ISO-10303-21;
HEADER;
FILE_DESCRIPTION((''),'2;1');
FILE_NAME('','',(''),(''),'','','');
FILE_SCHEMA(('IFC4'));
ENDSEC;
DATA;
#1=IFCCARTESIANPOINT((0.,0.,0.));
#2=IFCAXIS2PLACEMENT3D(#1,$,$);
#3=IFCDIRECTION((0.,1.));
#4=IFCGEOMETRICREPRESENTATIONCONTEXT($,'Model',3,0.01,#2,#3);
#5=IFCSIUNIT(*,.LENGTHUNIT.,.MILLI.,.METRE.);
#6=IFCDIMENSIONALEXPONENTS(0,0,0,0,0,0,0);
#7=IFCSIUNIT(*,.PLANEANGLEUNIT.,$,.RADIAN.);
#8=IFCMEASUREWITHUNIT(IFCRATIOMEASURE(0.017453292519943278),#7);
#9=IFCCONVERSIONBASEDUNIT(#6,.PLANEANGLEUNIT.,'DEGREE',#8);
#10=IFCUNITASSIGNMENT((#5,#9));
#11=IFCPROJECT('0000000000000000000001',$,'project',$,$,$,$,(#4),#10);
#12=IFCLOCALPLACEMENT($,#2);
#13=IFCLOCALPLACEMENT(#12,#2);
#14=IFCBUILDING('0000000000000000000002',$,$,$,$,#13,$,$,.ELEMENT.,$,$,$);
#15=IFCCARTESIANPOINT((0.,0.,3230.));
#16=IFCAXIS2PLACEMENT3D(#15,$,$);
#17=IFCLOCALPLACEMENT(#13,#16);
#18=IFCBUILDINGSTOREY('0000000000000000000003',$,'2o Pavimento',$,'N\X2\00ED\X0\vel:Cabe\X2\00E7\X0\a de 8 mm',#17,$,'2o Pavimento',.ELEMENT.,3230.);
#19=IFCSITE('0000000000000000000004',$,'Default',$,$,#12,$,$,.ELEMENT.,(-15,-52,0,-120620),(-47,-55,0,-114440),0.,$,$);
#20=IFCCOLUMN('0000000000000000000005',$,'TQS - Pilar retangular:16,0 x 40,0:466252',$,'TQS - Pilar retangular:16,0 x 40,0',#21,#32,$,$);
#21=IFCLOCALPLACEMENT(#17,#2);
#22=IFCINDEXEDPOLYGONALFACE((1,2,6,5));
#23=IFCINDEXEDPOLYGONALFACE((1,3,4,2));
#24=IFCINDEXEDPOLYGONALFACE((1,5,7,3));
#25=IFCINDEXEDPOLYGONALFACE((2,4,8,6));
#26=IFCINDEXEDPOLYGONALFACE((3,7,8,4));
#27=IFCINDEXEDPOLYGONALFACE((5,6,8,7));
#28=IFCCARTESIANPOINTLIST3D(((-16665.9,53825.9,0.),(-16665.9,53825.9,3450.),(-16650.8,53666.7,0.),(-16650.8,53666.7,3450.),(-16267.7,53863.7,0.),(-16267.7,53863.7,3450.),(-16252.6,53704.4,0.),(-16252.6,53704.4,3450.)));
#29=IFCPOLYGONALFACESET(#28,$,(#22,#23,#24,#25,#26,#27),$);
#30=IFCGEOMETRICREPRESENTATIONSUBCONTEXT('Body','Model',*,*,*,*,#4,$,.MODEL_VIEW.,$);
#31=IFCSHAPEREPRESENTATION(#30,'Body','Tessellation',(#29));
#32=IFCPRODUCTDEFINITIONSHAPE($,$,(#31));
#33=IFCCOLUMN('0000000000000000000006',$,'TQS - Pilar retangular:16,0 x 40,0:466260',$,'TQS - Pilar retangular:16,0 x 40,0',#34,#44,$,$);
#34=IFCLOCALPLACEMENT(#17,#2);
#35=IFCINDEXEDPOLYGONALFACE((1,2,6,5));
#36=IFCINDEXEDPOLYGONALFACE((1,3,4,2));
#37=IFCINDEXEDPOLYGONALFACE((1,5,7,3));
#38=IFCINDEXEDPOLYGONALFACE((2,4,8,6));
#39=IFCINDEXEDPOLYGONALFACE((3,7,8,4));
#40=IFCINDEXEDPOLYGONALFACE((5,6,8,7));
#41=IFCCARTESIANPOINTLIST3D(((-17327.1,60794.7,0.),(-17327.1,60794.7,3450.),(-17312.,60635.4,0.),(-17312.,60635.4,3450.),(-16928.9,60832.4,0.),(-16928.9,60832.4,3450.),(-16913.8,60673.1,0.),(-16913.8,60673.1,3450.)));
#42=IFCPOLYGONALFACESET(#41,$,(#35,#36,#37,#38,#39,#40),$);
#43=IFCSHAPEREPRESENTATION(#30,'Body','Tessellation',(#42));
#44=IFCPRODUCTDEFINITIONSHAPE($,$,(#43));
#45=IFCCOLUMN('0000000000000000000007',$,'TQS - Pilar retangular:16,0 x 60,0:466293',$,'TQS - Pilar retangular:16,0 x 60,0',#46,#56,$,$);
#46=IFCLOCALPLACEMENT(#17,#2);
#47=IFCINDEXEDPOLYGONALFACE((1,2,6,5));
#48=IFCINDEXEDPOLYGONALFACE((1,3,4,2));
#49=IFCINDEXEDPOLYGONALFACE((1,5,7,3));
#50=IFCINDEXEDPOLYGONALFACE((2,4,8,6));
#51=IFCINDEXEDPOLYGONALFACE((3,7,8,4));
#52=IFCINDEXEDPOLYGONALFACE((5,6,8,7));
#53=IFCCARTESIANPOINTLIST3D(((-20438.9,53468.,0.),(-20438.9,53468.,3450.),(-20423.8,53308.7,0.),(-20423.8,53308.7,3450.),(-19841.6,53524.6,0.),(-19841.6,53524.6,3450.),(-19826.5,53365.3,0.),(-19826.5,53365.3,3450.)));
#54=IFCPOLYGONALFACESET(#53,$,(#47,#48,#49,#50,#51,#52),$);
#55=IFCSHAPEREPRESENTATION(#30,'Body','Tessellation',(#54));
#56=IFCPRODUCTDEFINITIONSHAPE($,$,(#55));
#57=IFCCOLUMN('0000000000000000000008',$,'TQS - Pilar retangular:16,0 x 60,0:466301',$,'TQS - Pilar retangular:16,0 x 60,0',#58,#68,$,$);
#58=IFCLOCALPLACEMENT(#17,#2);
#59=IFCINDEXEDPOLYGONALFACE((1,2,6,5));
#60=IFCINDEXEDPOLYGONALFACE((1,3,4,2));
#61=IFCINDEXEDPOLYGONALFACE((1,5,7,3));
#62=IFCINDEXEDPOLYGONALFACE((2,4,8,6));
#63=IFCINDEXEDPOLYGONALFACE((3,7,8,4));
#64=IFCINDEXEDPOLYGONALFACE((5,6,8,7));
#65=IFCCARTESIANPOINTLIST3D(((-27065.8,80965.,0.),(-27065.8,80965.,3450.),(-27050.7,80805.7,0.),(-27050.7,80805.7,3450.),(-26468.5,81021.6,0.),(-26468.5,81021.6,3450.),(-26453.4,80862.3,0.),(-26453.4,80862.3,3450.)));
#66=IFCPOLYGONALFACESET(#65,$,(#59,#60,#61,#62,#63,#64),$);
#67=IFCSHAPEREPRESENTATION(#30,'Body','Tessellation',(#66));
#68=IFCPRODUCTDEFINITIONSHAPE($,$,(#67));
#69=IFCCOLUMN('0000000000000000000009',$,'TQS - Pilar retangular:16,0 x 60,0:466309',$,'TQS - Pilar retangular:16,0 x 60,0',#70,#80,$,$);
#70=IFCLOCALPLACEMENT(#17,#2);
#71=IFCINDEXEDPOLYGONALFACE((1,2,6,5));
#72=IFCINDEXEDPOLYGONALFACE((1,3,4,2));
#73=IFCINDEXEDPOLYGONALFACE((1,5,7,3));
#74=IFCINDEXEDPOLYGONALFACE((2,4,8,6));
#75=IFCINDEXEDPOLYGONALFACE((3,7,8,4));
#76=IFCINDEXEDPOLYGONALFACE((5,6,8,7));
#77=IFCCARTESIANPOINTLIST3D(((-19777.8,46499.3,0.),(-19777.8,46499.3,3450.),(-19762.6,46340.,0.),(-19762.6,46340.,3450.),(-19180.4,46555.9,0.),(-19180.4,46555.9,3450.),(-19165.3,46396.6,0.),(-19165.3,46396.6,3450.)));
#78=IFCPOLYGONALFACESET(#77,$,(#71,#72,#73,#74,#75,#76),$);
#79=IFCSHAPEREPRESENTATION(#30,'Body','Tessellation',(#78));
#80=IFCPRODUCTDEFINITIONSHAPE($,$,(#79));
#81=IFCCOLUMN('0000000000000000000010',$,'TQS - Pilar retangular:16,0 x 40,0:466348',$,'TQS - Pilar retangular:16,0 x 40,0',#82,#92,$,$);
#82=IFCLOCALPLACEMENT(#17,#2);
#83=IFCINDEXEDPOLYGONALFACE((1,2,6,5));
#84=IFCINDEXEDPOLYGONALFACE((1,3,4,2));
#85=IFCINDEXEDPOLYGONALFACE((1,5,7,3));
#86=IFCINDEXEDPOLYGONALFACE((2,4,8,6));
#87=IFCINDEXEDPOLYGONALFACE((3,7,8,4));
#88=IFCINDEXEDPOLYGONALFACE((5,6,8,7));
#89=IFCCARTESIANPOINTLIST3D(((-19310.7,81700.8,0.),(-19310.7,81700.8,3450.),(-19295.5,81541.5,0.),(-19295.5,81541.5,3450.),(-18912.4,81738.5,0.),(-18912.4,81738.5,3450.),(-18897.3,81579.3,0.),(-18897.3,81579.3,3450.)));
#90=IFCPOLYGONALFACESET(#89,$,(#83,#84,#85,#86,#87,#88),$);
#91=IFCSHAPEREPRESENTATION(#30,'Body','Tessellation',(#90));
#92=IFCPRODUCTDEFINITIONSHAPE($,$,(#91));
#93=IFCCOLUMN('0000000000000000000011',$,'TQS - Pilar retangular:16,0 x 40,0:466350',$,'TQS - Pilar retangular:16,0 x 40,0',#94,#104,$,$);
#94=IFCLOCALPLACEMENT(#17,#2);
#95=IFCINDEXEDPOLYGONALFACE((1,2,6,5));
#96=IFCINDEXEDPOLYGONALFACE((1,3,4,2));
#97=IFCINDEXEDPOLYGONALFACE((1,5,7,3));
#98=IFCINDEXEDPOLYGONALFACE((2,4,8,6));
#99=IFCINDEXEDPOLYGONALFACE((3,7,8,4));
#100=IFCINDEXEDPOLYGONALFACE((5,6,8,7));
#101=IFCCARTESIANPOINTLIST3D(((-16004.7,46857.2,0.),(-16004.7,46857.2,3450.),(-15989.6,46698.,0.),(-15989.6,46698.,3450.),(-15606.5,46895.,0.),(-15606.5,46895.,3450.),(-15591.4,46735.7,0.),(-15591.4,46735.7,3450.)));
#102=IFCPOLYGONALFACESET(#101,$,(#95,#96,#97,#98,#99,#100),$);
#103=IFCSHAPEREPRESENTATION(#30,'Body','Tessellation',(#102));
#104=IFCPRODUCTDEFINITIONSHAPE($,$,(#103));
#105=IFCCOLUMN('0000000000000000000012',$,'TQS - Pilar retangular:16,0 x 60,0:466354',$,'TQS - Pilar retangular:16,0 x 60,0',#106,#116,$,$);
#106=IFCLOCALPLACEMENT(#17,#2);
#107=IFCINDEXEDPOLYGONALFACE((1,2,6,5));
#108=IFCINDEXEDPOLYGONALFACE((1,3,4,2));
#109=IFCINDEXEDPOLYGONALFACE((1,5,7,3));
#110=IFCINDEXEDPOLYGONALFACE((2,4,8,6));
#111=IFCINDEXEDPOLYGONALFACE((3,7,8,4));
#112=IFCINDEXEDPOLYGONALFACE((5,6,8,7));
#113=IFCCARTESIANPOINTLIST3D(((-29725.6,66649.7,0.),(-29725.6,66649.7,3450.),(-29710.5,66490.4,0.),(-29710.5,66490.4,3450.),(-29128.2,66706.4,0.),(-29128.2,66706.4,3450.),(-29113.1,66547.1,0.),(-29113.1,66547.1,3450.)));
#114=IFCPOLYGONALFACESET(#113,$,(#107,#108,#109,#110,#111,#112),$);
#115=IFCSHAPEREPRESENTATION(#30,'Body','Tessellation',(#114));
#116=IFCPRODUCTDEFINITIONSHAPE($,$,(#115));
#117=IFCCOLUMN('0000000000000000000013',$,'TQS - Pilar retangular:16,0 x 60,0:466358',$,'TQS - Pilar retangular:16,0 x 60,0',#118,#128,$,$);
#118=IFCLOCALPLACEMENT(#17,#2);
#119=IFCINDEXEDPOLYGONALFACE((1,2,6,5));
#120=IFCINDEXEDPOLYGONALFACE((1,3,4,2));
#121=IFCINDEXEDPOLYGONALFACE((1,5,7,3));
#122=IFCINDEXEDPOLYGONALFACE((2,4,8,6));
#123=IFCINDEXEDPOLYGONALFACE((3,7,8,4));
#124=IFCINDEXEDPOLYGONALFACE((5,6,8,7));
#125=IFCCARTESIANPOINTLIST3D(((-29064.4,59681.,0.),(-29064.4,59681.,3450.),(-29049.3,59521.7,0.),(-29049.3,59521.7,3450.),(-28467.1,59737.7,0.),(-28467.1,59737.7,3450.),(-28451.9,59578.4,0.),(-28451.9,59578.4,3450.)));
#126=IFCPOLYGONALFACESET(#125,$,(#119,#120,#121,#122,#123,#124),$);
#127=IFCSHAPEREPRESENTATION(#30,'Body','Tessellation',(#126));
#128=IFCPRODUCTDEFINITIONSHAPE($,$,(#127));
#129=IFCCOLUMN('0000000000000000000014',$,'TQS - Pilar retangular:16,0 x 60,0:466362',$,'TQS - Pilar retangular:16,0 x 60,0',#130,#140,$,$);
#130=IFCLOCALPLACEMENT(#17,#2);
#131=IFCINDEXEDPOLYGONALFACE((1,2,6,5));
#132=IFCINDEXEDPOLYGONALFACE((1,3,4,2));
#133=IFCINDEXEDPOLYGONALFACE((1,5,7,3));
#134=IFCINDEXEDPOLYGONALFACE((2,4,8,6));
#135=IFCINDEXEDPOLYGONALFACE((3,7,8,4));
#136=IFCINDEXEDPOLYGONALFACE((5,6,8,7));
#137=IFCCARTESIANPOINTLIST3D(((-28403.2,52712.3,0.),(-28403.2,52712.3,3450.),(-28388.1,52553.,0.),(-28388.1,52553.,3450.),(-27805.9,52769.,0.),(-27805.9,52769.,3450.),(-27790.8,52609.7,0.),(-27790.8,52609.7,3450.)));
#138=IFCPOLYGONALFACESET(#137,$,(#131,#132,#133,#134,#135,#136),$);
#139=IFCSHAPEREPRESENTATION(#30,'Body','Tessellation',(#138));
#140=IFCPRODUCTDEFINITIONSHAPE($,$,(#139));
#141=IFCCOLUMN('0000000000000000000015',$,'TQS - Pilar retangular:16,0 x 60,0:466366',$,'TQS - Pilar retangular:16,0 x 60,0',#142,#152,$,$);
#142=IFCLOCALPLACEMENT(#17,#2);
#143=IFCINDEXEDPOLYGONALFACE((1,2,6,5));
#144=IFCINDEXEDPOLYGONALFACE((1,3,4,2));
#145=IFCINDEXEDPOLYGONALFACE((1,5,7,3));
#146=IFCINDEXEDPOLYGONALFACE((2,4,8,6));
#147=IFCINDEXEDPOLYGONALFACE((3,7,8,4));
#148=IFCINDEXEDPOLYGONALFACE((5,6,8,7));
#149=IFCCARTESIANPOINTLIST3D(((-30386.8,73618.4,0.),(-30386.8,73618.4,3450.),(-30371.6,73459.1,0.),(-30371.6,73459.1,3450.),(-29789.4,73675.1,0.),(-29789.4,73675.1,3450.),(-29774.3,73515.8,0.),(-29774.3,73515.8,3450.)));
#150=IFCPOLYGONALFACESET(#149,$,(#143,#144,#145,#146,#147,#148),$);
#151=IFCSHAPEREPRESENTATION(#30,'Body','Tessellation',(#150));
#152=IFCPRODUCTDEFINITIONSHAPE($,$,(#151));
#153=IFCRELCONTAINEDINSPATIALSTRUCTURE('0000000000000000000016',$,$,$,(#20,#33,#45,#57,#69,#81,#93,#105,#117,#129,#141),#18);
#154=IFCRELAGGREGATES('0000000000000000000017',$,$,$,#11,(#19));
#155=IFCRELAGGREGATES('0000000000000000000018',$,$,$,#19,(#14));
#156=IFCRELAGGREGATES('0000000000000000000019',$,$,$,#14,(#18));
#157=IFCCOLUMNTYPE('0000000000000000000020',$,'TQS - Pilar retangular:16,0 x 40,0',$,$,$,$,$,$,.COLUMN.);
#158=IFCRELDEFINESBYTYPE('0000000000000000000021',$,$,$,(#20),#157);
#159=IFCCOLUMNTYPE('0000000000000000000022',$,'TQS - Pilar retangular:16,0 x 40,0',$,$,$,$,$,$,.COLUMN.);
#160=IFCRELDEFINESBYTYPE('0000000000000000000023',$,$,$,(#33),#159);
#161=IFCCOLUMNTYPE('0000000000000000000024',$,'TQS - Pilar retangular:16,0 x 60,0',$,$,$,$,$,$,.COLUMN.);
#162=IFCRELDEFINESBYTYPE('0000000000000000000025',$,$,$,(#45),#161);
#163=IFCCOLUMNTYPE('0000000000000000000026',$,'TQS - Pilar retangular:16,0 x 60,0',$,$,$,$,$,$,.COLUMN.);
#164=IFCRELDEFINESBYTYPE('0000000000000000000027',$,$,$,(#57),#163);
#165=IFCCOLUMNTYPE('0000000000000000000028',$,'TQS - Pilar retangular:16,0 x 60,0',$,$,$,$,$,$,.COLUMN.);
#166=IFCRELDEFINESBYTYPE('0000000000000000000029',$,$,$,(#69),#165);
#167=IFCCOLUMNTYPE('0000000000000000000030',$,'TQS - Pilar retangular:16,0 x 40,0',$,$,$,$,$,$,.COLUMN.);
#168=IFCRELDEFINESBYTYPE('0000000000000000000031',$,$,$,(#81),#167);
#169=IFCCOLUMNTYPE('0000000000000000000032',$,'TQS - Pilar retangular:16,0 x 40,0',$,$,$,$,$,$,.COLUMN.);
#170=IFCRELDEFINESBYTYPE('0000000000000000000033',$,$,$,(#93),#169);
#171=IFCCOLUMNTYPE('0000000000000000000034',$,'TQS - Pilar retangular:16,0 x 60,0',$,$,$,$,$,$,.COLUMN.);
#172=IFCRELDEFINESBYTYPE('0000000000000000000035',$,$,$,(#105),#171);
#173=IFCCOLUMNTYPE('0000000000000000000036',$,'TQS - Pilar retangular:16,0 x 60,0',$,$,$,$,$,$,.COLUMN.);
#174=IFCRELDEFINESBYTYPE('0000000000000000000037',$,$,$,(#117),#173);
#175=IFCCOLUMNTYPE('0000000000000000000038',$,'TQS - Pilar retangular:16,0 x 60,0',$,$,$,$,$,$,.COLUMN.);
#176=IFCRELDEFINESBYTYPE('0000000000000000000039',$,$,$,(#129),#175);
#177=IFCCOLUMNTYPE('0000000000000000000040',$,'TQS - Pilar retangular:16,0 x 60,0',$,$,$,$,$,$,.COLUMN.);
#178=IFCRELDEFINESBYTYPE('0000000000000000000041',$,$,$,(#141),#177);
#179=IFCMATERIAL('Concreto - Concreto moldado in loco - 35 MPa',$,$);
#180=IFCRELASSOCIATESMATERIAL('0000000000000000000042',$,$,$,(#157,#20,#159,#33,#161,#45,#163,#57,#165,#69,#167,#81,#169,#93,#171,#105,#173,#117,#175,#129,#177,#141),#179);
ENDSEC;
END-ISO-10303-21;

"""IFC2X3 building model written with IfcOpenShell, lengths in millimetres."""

from ifc_helpers import new_model, entity, si_unit, converted_unit, direction, frame, frame_2d, origin, origin_2d_with_axis, place, context, subcontext, project, spatial, rectangle, extrude, source, transform, mapped, material, type_object, type_shapes, element, save


model = new_model("IFC2X3")

# Units and contexts
model_context = context("Model", 3, precision=0.01, world=origin(), true_north=direction((0.0, 1.0)))
body_context = subcontext(model_context, "Body", "Model", "MODEL_VIEW")
ifc_project = project(units=[si_unit("LENGTHUNIT", "METRE", prefix="MILLI"), converted_unit("PLANEANGLEUNIT", "DEGREE", entity("IfcRatioMeasure", 0.017453292519943278), si_unit("PLANEANGLEUNIT", "RADIAN"), dimensions=[0, 0, 0, 0, 0, 0, 0])], contexts=[model_context])

# Site, building, storey
site_placement = place(None, origin())
site = spatial("IfcSite", under=ifc_project, at=site_placement, Name="Default", CompositionType="ELEMENT", RefLatitude=(-15, -52, 0, -120620), RefLongitude=(-47, -55, 0, -114440), RefElevation=0.0)
building_placement = place(site_placement, origin())
building = spatial("IfcBuilding", under=site, at=building_placement, CompositionType="ELEMENT")
storey_placement = place(building_placement, frame((0.0, 0.0, 3230.0)))
storey = spatial("IfcBuildingStorey", under=building, at=storey_placement, Name="2o Pavimento", ObjectType="Nível:Cabeça de 8 mm", LongName="2o Pavimento", CompositionType="ELEMENT", Elevation=3230.0)

# Columns
ifc_material = material(Name="Concreto - Concreto moldado in loco - 35 MPa")
column_type_1 = type_object("IfcColumnType", Name="TQS - Pilar retangular:16,0 x 40,0", PredefinedType="COLUMN", material=ifc_material)
shared_shape_1 = source(origin(), body_context, "Body", "SweptSolid", [
    extrude(rectangle(XDim=400.0, YDim=160.0, at=origin_2d_with_axis()), frame((-16459.2, 53765.2, 3230.0), z_axis=(0.0, 0.0, 1.0), x_axis=(-0.995529, -0.094456, 0.0)), (0.0, 0.0, 1.0), 3450.0),
])
type_shapes(column_type_1, [shared_shape_1])
column_1_placement = place(storey_placement, frame((0.0, 0.0, -3230.0)))
element("IfcColumn", 1, at=column_1_placement, inside=storey, type_object=column_type_1, material=ifc_material, Name="TQS - Pilar retangular:16,0 x 40,0:466252", ObjectType="TQS - Pilar retangular:16,0 x 40,0", context=body_context, shape_type="MappedRepresentation", body=[
    mapped(shared_shape_1, transform((0.0, 0.0, 0.0), scale=1.0)),
])
column_type_2 = type_object("IfcColumnType", Name="TQS - Pilar retangular:16,0 x 40,0", PredefinedType="COLUMN", material=ifc_material)
shared_shape_2 = source(origin(), body_context, "Body", "SweptSolid", [
    extrude(rectangle(XDim=400.0, YDim=160.0, at=origin_2d_with_axis()), frame((-17120.4, 60733.9, 3230.0), z_axis=(0.0, 0.0, 1.0), x_axis=(-0.995529, -0.094456, 0.0)), (0.0, 0.0, 1.0), 3450.0),
])
type_shapes(column_type_2, [shared_shape_2])
column_2_placement = place(storey_placement, frame((0.0, 0.0, -3230.0)))
element("IfcColumn", 2, at=column_2_placement, inside=storey, type_object=column_type_2, material=ifc_material, Name="TQS - Pilar retangular:16,0 x 40,0:466260", ObjectType="TQS - Pilar retangular:16,0 x 40,0", context=body_context, shape_type="MappedRepresentation", body=[
    mapped(shared_shape_2, transform((0.0, 0.0, 0.0), scale=1.0)),
])
column_type_3 = type_object("IfcColumnType", Name="TQS - Pilar retangular:16,0 x 60,0", PredefinedType="COLUMN", material=ifc_material)
shared_shape_3 = source(origin(), body_context, "Body", "SweptSolid", [
    extrude(rectangle(XDim=600.0, YDim=160.0, at=origin_2d_with_axis()), frame((-20132.7, 53416.7, 3230.0), z_axis=(0.0, 0.0, 1.0), x_axis=(-0.995529, -0.094456, 0.0)), (0.0, 0.0, 1.0), 3450.0),
])
type_shapes(column_type_3, [shared_shape_3])
column_3_placement = place(storey_placement, frame((0.0, 0.0, -3230.0)))
element("IfcColumn", 3, at=column_3_placement, inside=storey, type_object=column_type_3, material=ifc_material, Name="TQS - Pilar retangular:16,0 x 60,0:466293", ObjectType="TQS - Pilar retangular:16,0 x 60,0", context=body_context, shape_type="MappedRepresentation", body=[
    mapped(shared_shape_3, transform((0.0, 0.0, 0.0), scale=1.0)),
])
column_type_4 = type_object("IfcColumnType", Name="TQS - Pilar retangular:16,0 x 60,0", PredefinedType="COLUMN", material=ifc_material)
shared_shape_4 = source(origin(), body_context, "Body", "SweptSolid", [
    extrude(rectangle(XDim=600.0, YDim=160.0, at=origin_2d_with_axis()), frame((-26759.6, 80913.6, 3230.0), z_axis=(0.0, 0.0, 1.0), x_axis=(-0.995529, -0.094456, 0.0)), (0.0, 0.0, 1.0), 3450.0),
])
type_shapes(column_type_4, [shared_shape_4])
column_4_placement = place(storey_placement, frame((0.0, 0.0, -3230.0)))
element("IfcColumn", 4, at=column_4_placement, inside=storey, type_object=column_type_4, material=ifc_material, Name="TQS - Pilar retangular:16,0 x 60,0:466301", ObjectType="TQS - Pilar retangular:16,0 x 60,0", context=body_context, shape_type="MappedRepresentation", body=[
    mapped(shared_shape_4, transform((0.0, 0.0, 0.0), scale=1.0)),
])
column_type_5 = type_object("IfcColumnType", Name="TQS - Pilar retangular:16,0 x 60,0", PredefinedType="COLUMN", material=ifc_material)
shared_shape_5 = source(origin(), body_context, "Body", "SweptSolid", [
    extrude(rectangle(XDim=600.0, YDim=160.0, at=origin_2d_with_axis()), frame((-19471.5, 46448.0, 3230.0), z_axis=(0.0, 0.0, 1.0), x_axis=(-0.995529, -0.094456, 0.0)), (0.0, 0.0, 1.0), 3450.0),
])
type_shapes(column_type_5, [shared_shape_5])
column_5_placement = place(storey_placement, frame((0.0, 0.0, -3230.0)))
element("IfcColumn", 5, at=column_5_placement, inside=storey, type_object=column_type_5, material=ifc_material, Name="TQS - Pilar retangular:16,0 x 60,0:466309", ObjectType="TQS - Pilar retangular:16,0 x 60,0", context=body_context, shape_type="MappedRepresentation", body=[
    mapped(shared_shape_5, transform((0.0, 0.0, 0.0), scale=1.0)),
])
column_type_6 = type_object("IfcColumnType", Name="TQS - Pilar retangular:16,0 x 40,0", PredefinedType="COLUMN", material=ifc_material)
shared_shape_6 = source(origin(), body_context, "Body", "SweptSolid", [
    extrude(rectangle(XDim=400.0, YDim=160.0, at=origin_2d_with_axis()), frame((-19104.0, 81640.0, 3230.0), z_axis=(0.0, 0.0, 1.0), x_axis=(-0.995529, -0.094456, 0.0)), (0.0, 0.0, 1.0), 3450.0),
])
type_shapes(column_type_6, [shared_shape_6])
column_6_placement = place(storey_placement, frame((0.0, 0.0, -3230.0)))
element("IfcColumn", 6, at=column_6_placement, inside=storey, type_object=column_type_6, material=ifc_material, Name="TQS - Pilar retangular:16,0 x 40,0:466348", ObjectType="TQS - Pilar retangular:16,0 x 40,0", context=body_context, shape_type="MappedRepresentation", body=[
    mapped(shared_shape_6, transform((0.0, 0.0, 0.0), scale=1.0)),
])
column_type_7 = type_object("IfcColumnType", Name="TQS - Pilar retangular:16,0 x 40,0", PredefinedType="COLUMN", material=ifc_material)
shared_shape_7 = source(origin(), body_context, "Body", "SweptSolid", [
    extrude(rectangle(XDim=400.0, YDim=160.0, at=frame_2d((0.0, 0.0), x_axis=(1.0, 0.0))), frame((-15798.0, 46796.5, 3230.0), z_axis=(0.0, 0.0, 1.0), x_axis=(-0.995529, -0.094456, 0.0)), (0.0, 0.0, 1.0), 3450.0),
])
type_shapes(column_type_7, [shared_shape_7])
column_7_placement = place(storey_placement, frame((0.0, 0.0, -3230.0)))
element("IfcColumn", 7, at=column_7_placement, inside=storey, type_object=column_type_7, material=ifc_material, Name="TQS - Pilar retangular:16,0 x 40,0:466350", ObjectType="TQS - Pilar retangular:16,0 x 40,0", context=body_context, shape_type="MappedRepresentation", body=[
    mapped(shared_shape_7, transform((0.0, 0.0, 0.0), scale=1.0)),
])
column_type_8 = type_object("IfcColumnType", Name="TQS - Pilar retangular:16,0 x 60,0", PredefinedType="COLUMN", material=ifc_material)
shared_shape_8 = source(origin(), body_context, "Body", "SweptSolid", [
    extrude(rectangle(XDim=600.0, YDim=160.0, at=origin_2d_with_axis()), frame((-29419.3, 66598.4, 3230.0), z_axis=(0.0, 0.0, 1.0), x_axis=(-0.995529, -0.094456, 0.0)), (0.0, 0.0, 1.0), 3450.0),
])
type_shapes(column_type_8, [shared_shape_8])
column_8_placement = place(storey_placement, frame((0.0, 0.0, -3230.0)))
element("IfcColumn", 8, at=column_8_placement, inside=storey, type_object=column_type_8, material=ifc_material, Name="TQS - Pilar retangular:16,0 x 60,0:466354", ObjectType="TQS - Pilar retangular:16,0 x 60,0", context=body_context, shape_type="MappedRepresentation", body=[
    mapped(shared_shape_8, transform((0.0, 0.0, 0.0), scale=1.0)),
])
column_type_9 = type_object("IfcColumnType", Name="TQS - Pilar retangular:16,0 x 60,0", PredefinedType="COLUMN", material=ifc_material)
shared_shape_9 = source(origin(), body_context, "Body", "SweptSolid", [
    extrude(rectangle(XDim=600.0, YDim=160.0, at=origin_2d_with_axis()), frame((-28758.2, 59629.7, 3230.0), z_axis=(0.0, 0.0, 1.0), x_axis=(-0.995529, -0.094456, 0.0)), (0.0, 0.0, 1.0), 3450.0),
])
type_shapes(column_type_9, [shared_shape_9])
column_9_placement = place(storey_placement, frame((0.0, 0.0, -3230.0)))
element("IfcColumn", 9, at=column_9_placement, inside=storey, type_object=column_type_9, material=ifc_material, Name="TQS - Pilar retangular:16,0 x 60,0:466358", ObjectType="TQS - Pilar retangular:16,0 x 60,0", context=body_context, shape_type="MappedRepresentation", body=[
    mapped(shared_shape_9, transform((0.0, 0.0, 0.0), scale=1.0)),
])
column_type_10 = type_object("IfcColumnType", Name="TQS - Pilar retangular:16,0 x 60,0", PredefinedType="COLUMN", material=ifc_material)
shared_shape_10 = source(origin(), body_context, "Body", "SweptSolid", [
    extrude(rectangle(XDim=600.0, YDim=160.0, at=origin_2d_with_axis()), frame((-28097.0, 52661.0, 3230.0), z_axis=(0.0, 0.0, 1.0), x_axis=(-0.995529, -0.094456, 0.0)), (0.0, 0.0, 1.0), 3450.0),
])
type_shapes(column_type_10, [shared_shape_10])
column_10_placement = place(storey_placement, frame((0.0, 0.0, -3230.0)))
element("IfcColumn", 10, at=column_10_placement, inside=storey, type_object=column_type_10, material=ifc_material, Name="TQS - Pilar retangular:16,0 x 60,0:466362", ObjectType="TQS - Pilar retangular:16,0 x 60,0", context=body_context, shape_type="MappedRepresentation", body=[
    mapped(shared_shape_10, transform((0.0, 0.0, 0.0), scale=1.0)),
])
column_type_11 = type_object("IfcColumnType", Name="TQS - Pilar retangular:16,0 x 60,0", PredefinedType="COLUMN", material=ifc_material)
shared_shape_11 = source(origin(), body_context, "Body", "SweptSolid", [
    extrude(rectangle(XDim=600.0, YDim=160.0, at=origin_2d_with_axis()), frame((-30080.5, 73567.1, 3230.0), z_axis=(0.0, 0.0, 1.0), x_axis=(-0.995529, -0.094456, 0.0)), (0.0, 0.0, 1.0), 3450.0),
])
type_shapes(column_type_11, [shared_shape_11])
column_11_placement = place(storey_placement, frame((0.0, 0.0, -3230.0)))
element("IfcColumn", 11, at=column_11_placement, inside=storey, type_object=column_type_11, material=ifc_material, Name="TQS - Pilar retangular:16,0 x 60,0:466366", ObjectType="TQS - Pilar retangular:16,0 x 60,0", context=body_context, shape_type="MappedRepresentation", body=[
    mapped(shared_shape_11, transform((0.0, 0.0, 0.0), scale=1.0)),
])

save(model, "model.ifc")
